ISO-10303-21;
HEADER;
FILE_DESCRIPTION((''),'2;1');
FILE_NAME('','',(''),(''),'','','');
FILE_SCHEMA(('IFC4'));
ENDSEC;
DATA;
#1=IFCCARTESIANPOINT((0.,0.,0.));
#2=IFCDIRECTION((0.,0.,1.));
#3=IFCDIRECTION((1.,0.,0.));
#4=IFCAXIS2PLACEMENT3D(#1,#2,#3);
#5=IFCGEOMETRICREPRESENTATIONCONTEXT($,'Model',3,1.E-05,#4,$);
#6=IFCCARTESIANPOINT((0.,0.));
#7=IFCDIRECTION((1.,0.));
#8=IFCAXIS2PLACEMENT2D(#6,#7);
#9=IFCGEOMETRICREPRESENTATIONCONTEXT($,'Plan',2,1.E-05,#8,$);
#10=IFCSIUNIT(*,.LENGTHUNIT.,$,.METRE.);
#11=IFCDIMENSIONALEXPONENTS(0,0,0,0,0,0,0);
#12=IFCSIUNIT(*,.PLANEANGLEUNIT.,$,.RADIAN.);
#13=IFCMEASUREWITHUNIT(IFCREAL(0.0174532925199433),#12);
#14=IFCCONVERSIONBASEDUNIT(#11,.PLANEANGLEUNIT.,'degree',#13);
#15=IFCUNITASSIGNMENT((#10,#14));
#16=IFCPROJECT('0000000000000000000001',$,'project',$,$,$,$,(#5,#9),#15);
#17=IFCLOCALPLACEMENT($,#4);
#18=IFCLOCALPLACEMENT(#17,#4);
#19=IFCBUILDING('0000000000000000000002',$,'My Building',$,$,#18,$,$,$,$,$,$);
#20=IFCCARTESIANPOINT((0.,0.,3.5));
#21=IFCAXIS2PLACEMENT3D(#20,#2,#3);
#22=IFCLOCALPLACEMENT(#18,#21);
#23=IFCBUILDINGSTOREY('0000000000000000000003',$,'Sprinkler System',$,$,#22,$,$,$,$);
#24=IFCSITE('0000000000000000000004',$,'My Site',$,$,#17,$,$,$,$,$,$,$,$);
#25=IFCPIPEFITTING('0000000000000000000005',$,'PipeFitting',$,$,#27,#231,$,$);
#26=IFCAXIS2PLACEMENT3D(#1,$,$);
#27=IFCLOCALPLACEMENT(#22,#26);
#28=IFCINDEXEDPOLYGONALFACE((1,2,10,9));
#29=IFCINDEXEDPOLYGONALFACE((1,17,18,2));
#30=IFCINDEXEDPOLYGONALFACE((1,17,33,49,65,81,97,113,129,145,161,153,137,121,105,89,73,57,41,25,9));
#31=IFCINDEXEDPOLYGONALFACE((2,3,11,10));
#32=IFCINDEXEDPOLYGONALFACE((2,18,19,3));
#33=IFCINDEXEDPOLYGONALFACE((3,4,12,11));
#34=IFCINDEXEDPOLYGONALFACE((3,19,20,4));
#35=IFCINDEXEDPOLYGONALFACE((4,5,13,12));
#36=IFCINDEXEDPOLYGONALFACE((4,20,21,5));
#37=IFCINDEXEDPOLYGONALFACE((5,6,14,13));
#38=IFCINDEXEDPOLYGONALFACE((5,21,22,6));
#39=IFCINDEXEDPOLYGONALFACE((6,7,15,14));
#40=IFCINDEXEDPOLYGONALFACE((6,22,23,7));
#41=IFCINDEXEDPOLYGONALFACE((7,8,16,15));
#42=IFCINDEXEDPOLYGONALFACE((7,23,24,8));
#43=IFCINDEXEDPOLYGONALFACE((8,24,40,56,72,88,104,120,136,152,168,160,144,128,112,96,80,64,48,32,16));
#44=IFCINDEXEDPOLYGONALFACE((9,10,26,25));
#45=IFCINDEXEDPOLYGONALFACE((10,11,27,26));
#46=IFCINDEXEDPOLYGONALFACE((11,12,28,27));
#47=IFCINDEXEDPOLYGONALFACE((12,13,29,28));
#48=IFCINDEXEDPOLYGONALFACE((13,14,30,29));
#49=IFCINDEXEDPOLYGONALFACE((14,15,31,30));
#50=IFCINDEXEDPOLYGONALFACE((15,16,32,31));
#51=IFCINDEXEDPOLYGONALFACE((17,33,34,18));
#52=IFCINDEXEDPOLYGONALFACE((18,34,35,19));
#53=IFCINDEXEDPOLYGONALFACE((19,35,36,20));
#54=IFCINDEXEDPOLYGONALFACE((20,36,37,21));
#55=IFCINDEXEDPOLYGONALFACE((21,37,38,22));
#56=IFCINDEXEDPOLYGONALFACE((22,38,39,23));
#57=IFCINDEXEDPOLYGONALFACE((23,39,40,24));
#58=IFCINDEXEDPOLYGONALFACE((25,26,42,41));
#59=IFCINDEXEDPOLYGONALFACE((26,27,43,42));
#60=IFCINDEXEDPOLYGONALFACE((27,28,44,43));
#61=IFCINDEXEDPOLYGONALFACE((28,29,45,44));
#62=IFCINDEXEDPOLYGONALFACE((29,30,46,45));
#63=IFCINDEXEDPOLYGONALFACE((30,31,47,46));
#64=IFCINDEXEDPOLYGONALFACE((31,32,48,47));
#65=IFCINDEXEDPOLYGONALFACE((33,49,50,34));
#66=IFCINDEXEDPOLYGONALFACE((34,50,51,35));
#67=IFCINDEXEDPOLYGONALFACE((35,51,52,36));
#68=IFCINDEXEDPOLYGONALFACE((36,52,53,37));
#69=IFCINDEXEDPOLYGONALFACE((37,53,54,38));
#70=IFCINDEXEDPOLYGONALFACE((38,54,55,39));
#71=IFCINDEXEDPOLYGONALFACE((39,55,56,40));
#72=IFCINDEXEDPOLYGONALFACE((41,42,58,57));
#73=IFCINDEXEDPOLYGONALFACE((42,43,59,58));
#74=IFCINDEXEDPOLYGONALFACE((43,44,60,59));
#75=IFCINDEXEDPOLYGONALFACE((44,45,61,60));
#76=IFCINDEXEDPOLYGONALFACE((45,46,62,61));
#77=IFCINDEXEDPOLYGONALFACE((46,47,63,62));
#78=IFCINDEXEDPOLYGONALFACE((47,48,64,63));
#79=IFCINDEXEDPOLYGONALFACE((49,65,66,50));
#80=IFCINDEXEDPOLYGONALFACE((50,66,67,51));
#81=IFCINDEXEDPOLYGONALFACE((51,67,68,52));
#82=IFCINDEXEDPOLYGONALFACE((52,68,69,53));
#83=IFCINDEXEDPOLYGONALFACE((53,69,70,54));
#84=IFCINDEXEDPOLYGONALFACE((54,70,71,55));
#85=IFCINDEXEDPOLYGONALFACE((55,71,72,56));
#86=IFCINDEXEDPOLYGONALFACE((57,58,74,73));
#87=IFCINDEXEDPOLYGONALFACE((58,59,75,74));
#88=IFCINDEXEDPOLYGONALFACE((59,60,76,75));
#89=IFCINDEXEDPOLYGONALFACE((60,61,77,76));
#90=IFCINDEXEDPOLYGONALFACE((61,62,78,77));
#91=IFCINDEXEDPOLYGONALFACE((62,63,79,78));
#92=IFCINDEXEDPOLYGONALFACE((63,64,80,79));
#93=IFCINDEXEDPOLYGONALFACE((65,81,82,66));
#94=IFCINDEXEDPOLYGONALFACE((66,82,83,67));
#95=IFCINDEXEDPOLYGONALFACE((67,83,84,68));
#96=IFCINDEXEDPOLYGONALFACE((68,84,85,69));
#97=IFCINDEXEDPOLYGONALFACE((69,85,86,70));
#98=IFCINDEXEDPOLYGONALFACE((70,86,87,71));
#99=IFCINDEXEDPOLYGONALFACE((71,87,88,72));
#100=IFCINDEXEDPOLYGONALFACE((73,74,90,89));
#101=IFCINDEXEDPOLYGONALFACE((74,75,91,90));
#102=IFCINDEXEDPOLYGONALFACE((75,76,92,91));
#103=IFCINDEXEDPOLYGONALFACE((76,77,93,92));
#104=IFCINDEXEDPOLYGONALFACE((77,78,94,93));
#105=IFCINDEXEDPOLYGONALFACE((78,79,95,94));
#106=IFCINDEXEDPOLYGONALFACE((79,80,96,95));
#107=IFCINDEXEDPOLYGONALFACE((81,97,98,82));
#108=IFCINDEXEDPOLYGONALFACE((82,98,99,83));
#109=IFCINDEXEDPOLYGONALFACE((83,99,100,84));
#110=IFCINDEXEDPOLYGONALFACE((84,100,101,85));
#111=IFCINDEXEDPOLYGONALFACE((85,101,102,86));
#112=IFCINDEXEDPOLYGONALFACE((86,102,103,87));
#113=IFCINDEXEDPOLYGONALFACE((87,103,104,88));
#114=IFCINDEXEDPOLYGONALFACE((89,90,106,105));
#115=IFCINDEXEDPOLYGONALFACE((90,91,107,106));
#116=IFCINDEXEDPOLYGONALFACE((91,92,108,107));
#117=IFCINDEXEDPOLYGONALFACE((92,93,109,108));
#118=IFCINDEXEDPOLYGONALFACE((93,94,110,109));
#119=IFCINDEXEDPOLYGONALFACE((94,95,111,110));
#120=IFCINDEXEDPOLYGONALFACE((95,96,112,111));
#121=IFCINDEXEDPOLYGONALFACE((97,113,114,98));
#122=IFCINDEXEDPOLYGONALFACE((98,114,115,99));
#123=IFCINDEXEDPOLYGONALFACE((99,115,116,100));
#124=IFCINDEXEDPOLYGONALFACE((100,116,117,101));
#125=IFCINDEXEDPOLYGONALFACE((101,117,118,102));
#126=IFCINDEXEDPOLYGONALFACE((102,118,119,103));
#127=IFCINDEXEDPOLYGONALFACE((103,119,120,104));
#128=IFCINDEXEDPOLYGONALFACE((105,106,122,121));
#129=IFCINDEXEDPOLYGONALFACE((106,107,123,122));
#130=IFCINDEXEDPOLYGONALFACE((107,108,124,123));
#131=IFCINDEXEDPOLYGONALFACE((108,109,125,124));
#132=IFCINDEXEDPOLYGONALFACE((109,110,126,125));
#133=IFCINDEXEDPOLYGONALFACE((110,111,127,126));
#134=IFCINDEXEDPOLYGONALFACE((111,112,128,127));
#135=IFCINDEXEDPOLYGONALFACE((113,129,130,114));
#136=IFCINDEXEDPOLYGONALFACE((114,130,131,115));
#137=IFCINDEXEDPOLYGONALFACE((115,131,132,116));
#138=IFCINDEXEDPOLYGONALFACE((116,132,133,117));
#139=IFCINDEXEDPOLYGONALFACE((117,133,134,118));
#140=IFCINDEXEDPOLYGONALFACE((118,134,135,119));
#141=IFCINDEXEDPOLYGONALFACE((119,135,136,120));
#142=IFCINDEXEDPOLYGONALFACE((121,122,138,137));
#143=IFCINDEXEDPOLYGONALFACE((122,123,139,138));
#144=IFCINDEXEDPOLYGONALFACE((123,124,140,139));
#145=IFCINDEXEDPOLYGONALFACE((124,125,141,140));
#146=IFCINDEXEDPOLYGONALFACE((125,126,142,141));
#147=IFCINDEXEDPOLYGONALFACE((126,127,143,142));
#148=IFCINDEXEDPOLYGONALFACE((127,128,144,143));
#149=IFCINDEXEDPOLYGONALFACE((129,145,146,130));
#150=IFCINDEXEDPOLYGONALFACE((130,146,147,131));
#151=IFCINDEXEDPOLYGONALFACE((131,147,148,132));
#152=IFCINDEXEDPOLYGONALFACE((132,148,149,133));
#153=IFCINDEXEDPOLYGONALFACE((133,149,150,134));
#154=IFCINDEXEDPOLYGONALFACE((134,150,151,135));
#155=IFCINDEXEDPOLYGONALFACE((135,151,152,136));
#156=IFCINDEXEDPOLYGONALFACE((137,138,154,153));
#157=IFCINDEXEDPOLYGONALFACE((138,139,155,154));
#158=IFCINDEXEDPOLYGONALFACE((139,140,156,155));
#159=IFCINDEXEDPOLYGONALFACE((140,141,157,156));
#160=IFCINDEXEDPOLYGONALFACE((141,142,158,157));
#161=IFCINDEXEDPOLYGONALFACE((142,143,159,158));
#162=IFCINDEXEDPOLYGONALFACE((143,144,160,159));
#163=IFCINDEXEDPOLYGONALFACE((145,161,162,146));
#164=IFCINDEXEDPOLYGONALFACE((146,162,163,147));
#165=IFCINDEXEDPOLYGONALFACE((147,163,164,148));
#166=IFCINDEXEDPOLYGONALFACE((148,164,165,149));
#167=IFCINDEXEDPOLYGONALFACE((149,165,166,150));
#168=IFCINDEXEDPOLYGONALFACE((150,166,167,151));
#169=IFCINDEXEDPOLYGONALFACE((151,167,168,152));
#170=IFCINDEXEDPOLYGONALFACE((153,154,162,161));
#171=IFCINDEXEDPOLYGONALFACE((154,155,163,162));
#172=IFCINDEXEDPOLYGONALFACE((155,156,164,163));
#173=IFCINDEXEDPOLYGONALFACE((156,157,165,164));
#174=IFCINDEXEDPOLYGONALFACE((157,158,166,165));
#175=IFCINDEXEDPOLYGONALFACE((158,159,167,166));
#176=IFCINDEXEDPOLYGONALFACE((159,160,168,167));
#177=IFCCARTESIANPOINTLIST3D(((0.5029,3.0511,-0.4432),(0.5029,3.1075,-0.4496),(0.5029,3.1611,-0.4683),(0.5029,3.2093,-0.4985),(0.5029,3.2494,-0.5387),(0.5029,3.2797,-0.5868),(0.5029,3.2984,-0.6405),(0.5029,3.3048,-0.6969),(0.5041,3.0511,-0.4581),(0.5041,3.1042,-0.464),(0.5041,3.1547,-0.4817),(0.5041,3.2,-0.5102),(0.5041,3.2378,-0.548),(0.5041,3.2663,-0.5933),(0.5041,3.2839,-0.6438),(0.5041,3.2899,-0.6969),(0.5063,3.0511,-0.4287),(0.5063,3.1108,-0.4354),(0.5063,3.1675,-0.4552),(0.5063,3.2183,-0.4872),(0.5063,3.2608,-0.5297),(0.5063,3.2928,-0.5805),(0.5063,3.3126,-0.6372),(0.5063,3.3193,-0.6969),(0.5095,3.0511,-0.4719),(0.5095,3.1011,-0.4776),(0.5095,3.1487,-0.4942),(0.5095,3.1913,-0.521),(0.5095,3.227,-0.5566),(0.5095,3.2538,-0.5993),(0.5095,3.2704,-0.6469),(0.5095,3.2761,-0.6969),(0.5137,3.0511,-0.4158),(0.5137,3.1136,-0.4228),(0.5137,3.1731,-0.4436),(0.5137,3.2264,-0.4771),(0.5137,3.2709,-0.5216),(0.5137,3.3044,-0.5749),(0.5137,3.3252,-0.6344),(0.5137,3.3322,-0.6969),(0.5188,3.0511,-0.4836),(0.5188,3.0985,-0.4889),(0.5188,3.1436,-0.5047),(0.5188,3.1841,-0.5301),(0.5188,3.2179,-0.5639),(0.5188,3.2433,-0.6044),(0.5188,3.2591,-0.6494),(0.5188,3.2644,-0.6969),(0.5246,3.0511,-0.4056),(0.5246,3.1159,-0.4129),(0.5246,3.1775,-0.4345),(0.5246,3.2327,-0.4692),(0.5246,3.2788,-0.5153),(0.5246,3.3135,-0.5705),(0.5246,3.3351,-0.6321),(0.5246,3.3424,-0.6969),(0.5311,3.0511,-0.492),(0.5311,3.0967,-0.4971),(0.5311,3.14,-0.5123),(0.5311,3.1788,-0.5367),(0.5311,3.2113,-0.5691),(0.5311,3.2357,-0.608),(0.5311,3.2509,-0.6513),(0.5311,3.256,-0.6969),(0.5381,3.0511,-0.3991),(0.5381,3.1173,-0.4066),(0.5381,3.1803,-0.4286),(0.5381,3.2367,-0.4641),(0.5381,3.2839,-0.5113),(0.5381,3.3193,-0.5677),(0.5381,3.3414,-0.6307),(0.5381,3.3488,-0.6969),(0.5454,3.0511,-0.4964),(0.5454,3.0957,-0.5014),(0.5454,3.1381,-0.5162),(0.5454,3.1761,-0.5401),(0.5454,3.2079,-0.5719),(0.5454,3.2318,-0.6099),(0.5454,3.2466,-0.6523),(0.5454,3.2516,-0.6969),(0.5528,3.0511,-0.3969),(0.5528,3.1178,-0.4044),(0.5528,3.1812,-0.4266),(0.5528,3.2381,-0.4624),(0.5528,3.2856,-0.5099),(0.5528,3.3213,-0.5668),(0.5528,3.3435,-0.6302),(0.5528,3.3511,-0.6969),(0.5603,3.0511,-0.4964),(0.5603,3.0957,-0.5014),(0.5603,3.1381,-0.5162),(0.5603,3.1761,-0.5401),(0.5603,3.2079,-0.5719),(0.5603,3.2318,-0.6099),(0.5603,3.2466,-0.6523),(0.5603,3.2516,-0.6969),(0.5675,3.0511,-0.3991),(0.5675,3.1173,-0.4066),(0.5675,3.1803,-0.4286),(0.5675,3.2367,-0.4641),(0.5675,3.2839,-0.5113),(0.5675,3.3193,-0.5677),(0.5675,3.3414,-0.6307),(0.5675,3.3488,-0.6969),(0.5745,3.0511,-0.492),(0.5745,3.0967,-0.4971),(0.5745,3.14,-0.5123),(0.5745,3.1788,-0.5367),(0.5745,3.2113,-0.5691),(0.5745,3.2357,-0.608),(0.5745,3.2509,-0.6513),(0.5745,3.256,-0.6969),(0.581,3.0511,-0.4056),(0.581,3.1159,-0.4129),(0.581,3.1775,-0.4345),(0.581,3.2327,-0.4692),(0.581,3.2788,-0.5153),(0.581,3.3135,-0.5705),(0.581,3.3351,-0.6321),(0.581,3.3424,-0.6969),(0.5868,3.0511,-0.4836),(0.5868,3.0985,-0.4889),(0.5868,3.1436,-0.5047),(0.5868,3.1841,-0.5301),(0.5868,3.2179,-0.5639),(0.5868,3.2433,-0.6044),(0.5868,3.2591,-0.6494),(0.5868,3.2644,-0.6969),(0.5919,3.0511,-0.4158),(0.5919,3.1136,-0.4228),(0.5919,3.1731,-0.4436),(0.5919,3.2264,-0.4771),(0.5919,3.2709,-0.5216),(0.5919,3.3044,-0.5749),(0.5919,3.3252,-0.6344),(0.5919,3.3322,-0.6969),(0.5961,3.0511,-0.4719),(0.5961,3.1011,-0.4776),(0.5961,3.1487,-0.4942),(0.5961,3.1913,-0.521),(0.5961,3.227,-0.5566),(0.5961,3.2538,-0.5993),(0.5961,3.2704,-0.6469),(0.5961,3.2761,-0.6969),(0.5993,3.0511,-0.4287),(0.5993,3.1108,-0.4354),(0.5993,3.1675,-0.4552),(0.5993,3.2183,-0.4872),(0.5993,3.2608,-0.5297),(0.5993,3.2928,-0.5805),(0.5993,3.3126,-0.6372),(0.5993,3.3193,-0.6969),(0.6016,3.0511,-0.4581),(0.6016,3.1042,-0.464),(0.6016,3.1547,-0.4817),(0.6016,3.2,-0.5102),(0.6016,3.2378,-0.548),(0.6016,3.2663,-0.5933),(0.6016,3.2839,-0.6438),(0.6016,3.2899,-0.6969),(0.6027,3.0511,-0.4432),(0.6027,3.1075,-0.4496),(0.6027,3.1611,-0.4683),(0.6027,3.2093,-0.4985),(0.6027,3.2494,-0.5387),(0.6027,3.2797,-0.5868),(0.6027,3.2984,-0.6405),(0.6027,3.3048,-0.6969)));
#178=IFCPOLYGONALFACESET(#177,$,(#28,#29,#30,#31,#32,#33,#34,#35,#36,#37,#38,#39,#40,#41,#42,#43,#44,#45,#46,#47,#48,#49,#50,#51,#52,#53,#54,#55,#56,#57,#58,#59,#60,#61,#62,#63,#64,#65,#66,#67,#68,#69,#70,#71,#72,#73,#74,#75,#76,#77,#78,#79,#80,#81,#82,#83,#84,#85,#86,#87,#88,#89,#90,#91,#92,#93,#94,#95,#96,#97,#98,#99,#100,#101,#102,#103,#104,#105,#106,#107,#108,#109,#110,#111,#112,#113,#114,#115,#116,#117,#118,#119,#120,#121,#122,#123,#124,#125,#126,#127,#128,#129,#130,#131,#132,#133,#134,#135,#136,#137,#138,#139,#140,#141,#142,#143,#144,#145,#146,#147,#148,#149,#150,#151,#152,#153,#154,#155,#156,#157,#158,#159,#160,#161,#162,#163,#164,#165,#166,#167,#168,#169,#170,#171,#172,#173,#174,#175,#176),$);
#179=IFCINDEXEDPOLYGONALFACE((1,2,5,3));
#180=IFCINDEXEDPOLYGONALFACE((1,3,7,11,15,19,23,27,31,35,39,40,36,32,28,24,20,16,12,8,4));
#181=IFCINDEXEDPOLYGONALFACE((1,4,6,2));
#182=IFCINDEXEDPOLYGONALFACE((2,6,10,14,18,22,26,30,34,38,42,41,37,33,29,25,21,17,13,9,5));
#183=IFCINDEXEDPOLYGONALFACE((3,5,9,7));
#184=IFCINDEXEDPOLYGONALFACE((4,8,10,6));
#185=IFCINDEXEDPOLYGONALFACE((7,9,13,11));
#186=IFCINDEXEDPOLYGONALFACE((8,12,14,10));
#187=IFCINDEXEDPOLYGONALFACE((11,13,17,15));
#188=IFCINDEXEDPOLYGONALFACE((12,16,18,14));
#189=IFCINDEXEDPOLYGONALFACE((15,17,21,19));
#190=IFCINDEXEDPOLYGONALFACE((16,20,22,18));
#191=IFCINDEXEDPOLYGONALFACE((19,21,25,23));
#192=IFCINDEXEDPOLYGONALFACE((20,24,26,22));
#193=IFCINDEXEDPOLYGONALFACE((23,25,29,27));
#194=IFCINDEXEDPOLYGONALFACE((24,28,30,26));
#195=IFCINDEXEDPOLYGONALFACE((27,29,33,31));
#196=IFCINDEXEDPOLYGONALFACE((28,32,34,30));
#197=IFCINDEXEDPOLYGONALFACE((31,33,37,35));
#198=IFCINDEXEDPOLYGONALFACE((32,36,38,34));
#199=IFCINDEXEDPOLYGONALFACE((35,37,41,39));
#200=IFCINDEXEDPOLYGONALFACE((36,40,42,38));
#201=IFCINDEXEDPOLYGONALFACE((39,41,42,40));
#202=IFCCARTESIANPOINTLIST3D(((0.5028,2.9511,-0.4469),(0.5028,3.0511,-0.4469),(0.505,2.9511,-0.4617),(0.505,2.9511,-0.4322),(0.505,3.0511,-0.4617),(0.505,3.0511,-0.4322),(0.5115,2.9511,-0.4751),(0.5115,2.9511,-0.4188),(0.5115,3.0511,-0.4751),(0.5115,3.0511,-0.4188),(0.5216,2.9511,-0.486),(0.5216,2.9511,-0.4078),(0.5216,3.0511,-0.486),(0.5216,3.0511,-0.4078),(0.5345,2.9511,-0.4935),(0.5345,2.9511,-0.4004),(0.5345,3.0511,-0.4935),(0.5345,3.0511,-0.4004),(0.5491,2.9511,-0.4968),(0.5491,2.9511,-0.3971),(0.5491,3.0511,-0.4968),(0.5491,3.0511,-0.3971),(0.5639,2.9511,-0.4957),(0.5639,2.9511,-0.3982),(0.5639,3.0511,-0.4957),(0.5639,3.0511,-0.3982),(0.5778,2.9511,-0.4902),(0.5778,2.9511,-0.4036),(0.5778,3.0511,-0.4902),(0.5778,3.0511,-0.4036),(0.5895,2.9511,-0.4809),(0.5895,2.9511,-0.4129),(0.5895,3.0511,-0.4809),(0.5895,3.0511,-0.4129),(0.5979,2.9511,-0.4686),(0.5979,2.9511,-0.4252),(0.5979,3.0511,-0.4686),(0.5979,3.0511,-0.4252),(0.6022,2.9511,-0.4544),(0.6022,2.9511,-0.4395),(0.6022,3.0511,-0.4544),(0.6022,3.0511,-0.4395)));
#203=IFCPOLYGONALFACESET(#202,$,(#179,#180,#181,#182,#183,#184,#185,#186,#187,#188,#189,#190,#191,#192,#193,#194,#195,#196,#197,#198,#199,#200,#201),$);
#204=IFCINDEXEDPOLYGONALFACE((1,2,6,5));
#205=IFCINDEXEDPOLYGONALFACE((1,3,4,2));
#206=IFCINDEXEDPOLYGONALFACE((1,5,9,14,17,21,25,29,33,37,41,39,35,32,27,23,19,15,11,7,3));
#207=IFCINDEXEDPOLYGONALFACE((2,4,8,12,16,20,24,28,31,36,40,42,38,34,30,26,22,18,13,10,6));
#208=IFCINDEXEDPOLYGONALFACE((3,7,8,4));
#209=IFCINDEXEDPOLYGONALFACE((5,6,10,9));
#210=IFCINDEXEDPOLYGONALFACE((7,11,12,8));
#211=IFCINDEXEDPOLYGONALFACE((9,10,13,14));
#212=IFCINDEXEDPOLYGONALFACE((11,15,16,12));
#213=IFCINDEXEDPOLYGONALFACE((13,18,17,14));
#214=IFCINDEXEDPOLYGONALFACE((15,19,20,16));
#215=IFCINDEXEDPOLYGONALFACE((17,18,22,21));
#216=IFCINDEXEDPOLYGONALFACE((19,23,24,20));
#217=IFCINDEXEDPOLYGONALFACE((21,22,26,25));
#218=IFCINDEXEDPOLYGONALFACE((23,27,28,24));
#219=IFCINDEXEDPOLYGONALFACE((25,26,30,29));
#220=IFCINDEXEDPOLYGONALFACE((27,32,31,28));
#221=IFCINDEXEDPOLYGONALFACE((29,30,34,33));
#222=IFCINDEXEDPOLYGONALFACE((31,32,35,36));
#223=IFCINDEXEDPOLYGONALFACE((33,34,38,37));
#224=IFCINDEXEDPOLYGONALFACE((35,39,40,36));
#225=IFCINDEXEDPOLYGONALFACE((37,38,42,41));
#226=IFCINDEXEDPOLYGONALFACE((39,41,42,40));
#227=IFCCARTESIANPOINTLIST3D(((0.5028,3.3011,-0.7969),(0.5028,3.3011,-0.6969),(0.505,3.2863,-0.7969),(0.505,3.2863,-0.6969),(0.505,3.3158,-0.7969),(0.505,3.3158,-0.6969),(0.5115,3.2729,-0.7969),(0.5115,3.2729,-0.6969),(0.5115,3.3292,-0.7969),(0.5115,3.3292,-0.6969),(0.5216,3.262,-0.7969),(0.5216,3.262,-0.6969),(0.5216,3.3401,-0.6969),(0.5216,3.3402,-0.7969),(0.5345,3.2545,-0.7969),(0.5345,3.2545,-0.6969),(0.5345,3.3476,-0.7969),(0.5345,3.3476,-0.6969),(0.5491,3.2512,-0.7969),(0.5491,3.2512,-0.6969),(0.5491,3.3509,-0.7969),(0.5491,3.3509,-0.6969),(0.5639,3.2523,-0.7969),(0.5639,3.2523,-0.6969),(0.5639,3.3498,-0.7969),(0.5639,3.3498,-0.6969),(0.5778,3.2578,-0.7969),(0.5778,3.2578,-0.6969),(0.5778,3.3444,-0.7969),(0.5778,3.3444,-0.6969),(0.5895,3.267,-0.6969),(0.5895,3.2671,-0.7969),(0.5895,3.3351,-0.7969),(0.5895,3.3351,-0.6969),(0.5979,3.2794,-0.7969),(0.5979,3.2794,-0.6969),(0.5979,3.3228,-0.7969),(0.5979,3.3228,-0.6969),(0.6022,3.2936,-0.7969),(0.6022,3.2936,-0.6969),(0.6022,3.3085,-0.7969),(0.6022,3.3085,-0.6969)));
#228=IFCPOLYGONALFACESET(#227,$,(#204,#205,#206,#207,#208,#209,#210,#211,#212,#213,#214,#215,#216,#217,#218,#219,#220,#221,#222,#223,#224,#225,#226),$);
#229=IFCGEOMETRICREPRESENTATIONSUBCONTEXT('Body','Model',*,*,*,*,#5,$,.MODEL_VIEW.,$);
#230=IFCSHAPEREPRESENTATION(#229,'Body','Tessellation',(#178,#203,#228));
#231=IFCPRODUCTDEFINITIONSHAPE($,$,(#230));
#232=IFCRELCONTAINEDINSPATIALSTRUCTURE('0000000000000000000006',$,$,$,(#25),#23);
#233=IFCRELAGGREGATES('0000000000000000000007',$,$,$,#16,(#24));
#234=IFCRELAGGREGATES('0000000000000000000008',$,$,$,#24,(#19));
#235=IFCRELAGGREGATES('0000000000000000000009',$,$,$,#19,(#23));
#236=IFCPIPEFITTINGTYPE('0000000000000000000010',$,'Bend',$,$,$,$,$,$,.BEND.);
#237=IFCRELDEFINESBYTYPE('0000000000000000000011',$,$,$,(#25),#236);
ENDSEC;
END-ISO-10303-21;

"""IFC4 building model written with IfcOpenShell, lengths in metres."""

from ifc_helpers import new_model, entity, si_unit, converted_unit, frame, origin_with_axes, origin_2d_with_axis, place, context, subcontext, project, spatial, circle, extrude, source, transform, mapped, type_object, type_shapes, element, save


model = new_model("IFC4")

# Units and contexts
model_context = context("Model", 3, precision=1e-05, world=origin_with_axes())
plan_context = context("Plan", 2, precision=1e-05, world=origin_2d_with_axis())
body_context = subcontext(model_context, "Body", "Model", "MODEL_VIEW")
ifc_project = project(units=[si_unit("LENGTHUNIT", "METRE"), converted_unit("PLANEANGLEUNIT", "degree", entity("IfcReal", 0.0174532925199433), si_unit("PLANEANGLEUNIT", "RADIAN"), dimensions=[0, 0, 0, 0, 0, 0, 0])], contexts=[model_context, plan_context])

# Site, building, storey
site_placement = place(None, origin_with_axes())
site = spatial("IfcSite", under=ifc_project, at=site_placement, Name="My Site")
building_placement = place(site_placement, origin_with_axes())
building = spatial("IfcBuilding", under=site, at=building_placement, Name="My Building")
storey_placement = place(building_placement, frame((0.0, 0.0, 3.5), z_axis=(0.0, 0.0, 1.0), x_axis=(1.0, 0.0, 0.0)))
storey = spatial("IfcBuildingStorey", under=building, at=storey_placement, Name="Sprinkler System")

# Pipe fitting
pipe_fitting_type_1 = type_object("IfcPipeFittingType", Name="Bend", PredefinedType="BEND")
shared_shape_1 = source(origin_with_axes(), body_context, "Body", "SolidModel", [
    entity("IfcSweptDiskSolid", entity("IfcIndexedPolyCurve", entity("IfcCartesianPointList3D", [[0.0, 0.0, 0.1], [0.0, -0.0732, 0.2768], [0.0, -0.25, 0.35]]), [entity("IfcArcIndex", [1, 2, 3])]), 0.05),
    extrude(circle(Radius=0.05), origin_with_axes(), (0.0, 0.0, 1.0), 0.1),
    extrude(circle(Radius=0.05), frame((0.0, -0.25, 0.35), z_axis=(0.0, -1.0, 0.000044), x_axis=(1.0, 0.0, 0.0)), (0.0, 0.0, 1.0), 0.1),
])
type_shapes(pipe_fitting_type_1, [shared_shape_1])
for number, where, z_axis, x_axis, name in (
    (1, (0.5528, 2.9511, -0.4469), (0.0, 1.0, -0.00001), (-1.0, 0.0, 0.0), "PipeFitting"),
):
    element("IfcPipeFitting", number, at=place(storey_placement, frame(where, z_axis=z_axis, x_axis=x_axis)), inside=storey, type_object=pipe_fitting_type_1, Name=name, context=body_context, shape_type="MappedRepresentation", body=[
        mapped(shared_shape_1, transform((0.0, 0.0, 0.0), x_axis=(1.0, 0.0, 0.0), y_axis=(0.0, 1.0, 0.0), z_axis=(0.0, 0.0, 1.0), scale=1.0)),
    ])

save(model, "model.ifc")
